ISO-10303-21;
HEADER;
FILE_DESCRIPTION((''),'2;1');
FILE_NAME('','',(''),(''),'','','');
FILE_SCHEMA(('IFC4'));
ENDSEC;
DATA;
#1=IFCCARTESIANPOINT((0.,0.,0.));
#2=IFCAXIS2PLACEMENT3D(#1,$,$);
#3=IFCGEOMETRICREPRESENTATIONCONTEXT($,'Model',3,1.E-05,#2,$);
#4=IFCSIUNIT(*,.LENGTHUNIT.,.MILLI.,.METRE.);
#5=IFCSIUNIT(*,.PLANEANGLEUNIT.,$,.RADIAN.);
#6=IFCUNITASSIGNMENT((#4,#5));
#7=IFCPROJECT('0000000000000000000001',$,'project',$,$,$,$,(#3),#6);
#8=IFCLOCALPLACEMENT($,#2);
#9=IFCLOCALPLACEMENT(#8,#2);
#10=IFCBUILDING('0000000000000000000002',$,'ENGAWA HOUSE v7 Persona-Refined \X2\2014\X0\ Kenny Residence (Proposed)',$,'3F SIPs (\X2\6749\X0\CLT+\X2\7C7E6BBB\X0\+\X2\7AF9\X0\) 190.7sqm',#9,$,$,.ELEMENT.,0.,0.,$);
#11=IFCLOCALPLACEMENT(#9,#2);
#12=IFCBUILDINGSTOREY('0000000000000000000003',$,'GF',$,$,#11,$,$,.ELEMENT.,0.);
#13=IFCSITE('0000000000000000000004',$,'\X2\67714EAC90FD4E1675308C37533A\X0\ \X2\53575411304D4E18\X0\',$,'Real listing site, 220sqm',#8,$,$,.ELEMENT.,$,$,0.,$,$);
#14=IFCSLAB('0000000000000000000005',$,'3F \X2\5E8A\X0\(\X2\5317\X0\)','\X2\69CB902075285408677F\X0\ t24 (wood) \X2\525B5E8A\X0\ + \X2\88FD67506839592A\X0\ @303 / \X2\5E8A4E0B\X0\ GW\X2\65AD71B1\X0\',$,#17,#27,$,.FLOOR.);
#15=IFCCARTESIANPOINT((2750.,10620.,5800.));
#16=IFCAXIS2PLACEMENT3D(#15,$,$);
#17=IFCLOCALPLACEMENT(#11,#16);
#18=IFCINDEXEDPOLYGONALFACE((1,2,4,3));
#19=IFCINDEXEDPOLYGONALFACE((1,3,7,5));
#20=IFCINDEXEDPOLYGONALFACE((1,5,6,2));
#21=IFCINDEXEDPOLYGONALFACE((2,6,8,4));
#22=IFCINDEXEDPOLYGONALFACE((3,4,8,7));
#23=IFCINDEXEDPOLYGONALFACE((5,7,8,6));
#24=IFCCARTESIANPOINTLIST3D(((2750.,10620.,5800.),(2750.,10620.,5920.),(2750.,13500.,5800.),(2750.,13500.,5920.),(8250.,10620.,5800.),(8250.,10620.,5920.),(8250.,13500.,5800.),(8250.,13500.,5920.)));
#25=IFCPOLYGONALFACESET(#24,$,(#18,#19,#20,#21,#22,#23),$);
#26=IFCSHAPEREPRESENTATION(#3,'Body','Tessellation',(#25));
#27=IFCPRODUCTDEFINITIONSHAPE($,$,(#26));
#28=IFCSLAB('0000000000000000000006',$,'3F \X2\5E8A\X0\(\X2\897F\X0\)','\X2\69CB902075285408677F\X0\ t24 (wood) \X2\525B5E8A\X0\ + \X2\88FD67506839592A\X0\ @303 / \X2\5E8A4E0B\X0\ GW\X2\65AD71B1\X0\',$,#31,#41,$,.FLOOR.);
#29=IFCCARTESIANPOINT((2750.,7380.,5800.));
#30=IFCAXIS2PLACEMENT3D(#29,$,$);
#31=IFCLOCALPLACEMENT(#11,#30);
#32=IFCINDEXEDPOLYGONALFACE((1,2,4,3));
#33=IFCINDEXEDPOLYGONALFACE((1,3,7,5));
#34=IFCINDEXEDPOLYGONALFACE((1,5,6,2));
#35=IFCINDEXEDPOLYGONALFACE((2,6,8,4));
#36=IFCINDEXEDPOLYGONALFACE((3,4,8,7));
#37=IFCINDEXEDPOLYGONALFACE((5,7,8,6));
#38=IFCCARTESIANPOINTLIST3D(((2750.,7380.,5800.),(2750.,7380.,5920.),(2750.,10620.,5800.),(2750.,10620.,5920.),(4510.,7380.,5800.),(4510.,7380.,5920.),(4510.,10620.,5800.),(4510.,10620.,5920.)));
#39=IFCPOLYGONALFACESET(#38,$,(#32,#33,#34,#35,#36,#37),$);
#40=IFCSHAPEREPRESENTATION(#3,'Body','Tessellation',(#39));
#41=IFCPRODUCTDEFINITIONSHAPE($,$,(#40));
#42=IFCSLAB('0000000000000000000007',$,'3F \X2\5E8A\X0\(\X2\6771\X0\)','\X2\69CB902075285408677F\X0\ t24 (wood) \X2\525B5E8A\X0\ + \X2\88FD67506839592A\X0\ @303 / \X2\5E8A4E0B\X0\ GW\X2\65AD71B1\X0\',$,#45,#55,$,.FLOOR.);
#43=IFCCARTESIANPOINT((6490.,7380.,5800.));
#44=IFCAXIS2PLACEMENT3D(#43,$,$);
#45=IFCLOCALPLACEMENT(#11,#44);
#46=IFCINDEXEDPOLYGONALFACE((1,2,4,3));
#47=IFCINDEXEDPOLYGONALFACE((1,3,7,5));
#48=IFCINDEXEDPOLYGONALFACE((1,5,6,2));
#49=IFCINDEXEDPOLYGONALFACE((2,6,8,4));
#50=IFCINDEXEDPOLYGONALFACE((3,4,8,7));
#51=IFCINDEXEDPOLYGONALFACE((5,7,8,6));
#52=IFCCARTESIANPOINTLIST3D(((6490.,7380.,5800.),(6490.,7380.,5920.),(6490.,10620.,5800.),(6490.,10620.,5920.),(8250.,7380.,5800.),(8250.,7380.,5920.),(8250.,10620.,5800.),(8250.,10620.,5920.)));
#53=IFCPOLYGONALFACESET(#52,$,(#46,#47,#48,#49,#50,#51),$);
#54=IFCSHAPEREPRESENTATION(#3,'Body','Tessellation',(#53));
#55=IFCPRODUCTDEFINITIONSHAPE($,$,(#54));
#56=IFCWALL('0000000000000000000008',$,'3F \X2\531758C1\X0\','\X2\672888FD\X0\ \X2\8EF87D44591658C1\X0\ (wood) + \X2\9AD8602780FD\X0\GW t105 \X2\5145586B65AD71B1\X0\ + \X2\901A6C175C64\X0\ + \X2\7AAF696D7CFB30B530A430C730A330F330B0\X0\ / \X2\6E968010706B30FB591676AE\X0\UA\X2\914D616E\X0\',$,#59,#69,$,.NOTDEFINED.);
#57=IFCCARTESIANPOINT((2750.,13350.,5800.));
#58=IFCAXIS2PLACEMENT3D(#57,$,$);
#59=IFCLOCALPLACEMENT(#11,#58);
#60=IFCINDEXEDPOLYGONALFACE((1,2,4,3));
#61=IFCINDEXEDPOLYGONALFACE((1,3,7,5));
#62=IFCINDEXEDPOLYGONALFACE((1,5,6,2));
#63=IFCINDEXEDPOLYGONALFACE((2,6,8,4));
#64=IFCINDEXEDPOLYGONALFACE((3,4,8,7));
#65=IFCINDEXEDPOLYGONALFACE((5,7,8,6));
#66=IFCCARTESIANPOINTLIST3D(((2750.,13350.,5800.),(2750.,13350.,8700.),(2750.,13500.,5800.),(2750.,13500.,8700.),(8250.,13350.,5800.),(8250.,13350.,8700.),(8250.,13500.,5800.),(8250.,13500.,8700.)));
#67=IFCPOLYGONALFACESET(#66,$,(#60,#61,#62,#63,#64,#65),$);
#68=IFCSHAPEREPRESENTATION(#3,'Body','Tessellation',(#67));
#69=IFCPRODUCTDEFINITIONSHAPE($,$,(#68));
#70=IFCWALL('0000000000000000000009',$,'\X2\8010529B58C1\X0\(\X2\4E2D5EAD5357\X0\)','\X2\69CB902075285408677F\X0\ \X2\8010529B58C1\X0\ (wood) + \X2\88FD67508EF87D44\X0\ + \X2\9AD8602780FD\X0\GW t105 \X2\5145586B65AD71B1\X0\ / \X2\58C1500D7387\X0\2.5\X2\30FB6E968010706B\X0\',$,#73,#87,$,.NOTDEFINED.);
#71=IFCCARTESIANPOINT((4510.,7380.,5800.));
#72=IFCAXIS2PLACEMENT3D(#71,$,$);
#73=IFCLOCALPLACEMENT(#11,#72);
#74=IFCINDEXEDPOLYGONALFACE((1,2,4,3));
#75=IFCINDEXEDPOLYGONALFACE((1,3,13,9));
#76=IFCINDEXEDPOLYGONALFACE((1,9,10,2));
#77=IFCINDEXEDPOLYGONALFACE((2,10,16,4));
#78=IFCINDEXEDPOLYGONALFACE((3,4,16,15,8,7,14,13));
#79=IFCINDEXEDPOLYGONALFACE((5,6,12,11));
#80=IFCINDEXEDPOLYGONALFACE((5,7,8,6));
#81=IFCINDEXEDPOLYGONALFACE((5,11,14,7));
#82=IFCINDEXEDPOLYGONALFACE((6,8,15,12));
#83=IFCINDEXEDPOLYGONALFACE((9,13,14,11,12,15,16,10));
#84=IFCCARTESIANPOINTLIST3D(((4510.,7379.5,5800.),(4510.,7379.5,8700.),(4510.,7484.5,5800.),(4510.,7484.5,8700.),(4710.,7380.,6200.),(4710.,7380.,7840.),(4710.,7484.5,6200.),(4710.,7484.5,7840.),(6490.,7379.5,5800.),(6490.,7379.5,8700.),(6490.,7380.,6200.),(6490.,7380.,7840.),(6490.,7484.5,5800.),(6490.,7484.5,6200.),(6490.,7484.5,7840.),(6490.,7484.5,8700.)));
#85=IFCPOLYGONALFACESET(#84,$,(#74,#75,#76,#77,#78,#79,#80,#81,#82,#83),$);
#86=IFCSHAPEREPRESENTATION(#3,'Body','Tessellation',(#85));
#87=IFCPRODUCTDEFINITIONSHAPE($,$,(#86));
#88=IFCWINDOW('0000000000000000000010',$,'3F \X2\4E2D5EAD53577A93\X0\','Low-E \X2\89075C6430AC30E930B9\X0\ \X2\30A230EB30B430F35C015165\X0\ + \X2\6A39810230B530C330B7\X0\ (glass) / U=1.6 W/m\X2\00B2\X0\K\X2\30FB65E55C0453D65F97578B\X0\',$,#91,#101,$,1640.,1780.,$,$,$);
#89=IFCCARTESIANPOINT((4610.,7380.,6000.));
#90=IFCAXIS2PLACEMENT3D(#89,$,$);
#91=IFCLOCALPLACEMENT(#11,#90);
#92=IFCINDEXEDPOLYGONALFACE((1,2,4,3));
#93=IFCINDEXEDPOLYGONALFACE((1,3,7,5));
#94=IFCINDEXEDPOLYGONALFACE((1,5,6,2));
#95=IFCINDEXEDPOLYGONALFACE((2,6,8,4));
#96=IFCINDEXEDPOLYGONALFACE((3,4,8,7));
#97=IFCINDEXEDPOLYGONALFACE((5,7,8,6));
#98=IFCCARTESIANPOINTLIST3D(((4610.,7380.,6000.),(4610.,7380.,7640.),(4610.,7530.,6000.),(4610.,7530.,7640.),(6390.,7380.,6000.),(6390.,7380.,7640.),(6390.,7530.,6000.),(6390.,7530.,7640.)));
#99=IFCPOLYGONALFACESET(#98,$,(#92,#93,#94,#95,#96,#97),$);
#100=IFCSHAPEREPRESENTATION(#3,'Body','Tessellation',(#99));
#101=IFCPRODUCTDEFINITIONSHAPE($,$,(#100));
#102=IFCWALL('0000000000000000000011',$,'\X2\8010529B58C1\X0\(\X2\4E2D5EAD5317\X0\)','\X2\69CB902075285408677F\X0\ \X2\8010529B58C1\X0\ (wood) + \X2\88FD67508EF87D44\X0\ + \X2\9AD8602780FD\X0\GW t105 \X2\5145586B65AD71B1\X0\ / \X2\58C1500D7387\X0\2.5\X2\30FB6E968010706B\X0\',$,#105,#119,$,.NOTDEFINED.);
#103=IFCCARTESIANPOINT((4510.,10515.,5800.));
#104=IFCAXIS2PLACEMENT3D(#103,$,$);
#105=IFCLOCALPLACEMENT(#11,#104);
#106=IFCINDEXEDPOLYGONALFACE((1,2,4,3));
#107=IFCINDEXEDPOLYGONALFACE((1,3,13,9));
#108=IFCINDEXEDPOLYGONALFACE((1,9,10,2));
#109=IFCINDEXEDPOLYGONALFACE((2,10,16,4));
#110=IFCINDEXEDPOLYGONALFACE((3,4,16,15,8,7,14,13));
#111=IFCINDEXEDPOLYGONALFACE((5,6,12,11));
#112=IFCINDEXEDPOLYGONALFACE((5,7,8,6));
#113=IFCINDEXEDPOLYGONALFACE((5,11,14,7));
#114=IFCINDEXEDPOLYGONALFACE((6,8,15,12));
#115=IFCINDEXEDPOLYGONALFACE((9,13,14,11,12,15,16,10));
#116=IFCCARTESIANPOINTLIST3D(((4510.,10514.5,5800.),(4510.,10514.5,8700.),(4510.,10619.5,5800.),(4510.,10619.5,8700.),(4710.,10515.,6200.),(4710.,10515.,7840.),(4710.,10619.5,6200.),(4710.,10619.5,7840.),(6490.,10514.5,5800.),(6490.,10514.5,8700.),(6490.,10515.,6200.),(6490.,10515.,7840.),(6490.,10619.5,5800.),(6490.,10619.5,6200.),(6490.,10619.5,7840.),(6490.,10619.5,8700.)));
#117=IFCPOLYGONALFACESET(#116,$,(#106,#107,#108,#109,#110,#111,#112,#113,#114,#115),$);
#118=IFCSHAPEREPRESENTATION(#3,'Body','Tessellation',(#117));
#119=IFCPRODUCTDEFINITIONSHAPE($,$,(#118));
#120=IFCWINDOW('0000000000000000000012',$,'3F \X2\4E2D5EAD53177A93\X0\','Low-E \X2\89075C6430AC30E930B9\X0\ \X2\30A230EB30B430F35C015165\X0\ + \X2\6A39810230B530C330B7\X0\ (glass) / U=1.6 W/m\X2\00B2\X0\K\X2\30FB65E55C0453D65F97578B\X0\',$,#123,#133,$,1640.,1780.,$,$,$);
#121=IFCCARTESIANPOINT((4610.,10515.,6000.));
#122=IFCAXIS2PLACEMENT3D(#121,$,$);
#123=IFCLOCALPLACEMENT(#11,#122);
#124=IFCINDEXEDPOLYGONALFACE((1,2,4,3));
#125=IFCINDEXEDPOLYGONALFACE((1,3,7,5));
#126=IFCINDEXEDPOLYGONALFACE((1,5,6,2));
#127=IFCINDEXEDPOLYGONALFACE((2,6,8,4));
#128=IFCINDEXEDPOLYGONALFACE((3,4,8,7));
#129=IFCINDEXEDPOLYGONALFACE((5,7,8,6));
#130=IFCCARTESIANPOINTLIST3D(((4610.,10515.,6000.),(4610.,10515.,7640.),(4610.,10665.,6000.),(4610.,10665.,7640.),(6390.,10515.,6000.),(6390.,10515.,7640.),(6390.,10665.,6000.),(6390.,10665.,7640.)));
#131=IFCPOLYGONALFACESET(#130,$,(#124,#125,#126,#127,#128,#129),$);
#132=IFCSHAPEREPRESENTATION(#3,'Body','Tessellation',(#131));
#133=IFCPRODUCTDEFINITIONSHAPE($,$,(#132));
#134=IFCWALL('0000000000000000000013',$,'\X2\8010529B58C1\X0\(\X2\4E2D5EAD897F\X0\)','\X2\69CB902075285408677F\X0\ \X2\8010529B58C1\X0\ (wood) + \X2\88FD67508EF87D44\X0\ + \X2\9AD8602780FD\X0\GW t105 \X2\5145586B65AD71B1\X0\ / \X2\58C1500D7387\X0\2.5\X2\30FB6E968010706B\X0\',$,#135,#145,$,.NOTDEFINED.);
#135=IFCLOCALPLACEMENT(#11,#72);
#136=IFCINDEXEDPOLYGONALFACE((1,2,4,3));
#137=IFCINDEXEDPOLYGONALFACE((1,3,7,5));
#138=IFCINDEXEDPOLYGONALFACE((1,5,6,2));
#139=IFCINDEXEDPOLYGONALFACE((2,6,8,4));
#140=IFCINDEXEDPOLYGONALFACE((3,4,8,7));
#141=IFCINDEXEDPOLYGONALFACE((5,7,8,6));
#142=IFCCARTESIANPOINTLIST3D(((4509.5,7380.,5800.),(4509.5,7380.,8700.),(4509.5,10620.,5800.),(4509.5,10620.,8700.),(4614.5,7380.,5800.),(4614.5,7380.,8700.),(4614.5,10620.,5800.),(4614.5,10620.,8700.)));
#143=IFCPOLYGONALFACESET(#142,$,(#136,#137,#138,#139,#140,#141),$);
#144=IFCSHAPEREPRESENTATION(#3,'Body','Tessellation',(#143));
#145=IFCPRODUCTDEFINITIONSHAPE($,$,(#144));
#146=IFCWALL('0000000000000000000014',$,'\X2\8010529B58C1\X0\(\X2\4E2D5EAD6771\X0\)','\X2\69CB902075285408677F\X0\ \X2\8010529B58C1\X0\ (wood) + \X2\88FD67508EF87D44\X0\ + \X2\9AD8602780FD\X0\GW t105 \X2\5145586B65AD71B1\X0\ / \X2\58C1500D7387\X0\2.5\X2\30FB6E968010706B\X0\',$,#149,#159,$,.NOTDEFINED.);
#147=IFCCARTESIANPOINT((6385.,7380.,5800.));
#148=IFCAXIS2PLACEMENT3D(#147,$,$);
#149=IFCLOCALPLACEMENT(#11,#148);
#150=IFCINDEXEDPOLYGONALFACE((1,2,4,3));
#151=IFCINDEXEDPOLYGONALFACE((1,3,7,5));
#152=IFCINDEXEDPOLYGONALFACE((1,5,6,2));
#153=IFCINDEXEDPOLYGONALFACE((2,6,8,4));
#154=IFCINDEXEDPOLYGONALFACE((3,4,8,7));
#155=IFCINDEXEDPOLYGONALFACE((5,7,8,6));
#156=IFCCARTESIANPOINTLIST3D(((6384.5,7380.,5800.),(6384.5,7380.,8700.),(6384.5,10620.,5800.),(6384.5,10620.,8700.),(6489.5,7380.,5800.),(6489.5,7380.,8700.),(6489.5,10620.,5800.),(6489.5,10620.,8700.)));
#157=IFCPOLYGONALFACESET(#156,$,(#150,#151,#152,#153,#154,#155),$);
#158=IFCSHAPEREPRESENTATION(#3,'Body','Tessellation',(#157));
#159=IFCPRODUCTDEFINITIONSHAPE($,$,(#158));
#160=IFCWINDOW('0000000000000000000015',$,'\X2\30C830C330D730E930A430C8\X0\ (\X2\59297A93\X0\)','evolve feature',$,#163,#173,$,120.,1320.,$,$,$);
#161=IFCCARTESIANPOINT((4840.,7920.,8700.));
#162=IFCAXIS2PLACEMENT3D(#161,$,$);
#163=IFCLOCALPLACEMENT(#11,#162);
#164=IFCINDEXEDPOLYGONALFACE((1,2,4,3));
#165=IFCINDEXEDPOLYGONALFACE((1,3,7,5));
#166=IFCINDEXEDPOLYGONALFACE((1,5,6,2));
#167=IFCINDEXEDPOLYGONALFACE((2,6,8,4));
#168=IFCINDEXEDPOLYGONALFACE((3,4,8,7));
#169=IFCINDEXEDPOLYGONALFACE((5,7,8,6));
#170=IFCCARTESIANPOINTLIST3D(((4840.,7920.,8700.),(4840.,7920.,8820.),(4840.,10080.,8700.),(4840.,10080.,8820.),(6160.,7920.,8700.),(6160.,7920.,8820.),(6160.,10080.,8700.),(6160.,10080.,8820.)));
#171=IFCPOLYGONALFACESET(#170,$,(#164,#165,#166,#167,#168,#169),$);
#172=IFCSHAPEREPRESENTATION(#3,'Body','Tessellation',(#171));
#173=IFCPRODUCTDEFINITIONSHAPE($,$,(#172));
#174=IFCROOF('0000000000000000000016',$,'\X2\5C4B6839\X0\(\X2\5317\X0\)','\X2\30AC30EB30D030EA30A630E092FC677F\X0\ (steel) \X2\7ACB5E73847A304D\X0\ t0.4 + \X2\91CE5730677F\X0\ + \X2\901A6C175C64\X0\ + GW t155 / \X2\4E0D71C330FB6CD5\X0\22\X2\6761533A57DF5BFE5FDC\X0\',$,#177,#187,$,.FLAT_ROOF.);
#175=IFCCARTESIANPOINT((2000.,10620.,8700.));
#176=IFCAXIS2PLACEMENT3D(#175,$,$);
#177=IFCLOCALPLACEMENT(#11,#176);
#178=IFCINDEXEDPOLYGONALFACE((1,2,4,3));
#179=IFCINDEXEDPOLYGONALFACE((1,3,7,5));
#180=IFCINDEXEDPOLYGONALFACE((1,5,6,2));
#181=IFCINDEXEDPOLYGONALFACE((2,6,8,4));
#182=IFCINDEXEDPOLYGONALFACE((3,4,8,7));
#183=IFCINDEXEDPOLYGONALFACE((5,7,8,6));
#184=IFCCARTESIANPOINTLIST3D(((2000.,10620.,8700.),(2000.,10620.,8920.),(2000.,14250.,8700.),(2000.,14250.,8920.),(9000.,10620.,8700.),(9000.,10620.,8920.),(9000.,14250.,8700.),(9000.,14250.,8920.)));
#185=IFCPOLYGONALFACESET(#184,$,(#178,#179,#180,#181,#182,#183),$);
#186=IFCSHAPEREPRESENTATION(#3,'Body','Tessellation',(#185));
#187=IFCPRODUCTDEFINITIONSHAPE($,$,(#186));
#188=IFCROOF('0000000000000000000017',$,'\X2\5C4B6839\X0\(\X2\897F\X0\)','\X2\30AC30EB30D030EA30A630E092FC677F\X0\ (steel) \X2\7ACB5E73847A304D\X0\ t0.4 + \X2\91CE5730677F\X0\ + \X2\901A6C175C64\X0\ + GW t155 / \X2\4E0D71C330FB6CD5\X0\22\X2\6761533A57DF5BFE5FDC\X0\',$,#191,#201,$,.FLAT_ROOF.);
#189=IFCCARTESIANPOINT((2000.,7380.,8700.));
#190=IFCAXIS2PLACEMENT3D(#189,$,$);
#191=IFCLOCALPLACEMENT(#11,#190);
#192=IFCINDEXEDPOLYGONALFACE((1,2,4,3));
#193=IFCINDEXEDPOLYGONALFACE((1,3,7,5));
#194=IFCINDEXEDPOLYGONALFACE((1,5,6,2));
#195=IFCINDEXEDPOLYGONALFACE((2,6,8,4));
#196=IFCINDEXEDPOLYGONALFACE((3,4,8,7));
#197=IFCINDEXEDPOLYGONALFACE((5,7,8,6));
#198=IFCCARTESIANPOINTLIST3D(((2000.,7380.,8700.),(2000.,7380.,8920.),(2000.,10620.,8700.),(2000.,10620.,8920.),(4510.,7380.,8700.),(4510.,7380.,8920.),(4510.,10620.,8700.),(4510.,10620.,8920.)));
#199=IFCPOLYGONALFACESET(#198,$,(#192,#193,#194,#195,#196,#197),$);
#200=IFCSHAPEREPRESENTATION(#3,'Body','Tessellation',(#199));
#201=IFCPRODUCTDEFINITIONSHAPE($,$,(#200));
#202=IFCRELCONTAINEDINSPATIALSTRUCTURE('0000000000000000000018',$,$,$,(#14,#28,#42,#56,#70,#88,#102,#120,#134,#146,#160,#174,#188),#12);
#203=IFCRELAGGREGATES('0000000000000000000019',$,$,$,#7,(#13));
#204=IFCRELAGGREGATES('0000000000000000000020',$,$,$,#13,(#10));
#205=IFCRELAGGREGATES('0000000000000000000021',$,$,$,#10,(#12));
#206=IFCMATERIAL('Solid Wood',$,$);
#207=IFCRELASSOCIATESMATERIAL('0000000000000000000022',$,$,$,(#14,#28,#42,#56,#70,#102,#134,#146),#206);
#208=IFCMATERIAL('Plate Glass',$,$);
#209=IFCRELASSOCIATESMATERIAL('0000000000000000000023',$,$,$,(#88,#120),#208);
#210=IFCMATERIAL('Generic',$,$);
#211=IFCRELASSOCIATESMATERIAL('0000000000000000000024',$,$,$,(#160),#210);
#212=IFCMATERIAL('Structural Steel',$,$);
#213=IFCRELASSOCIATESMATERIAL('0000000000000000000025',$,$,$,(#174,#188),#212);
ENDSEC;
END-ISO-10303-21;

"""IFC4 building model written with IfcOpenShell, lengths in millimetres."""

from ifc_helpers import new_model, si_unit, frame, frame_2d, origin, place, context, project, spatial, rectangle, extrude, material, element, fill, save


model = new_model("IFC4")

# Units and contexts
model_context = context("Model", 3, precision=1e-05, world=origin())
ifc_project = project(units=[si_unit("LENGTHUNIT", "METRE", prefix="MILLI"), si_unit("PLANEANGLEUNIT", "RADIAN")], contexts=[model_context])

# Site, building, storey
site_placement = place(None, origin())
site = spatial("IfcSite", under=ifc_project, at=site_placement, Name="東京都世田谷区 南向き丘", ObjectType="Real listing site, 220sqm", CompositionType="ELEMENT", RefElevation=0.0)
building_placement = place(site_placement, origin())
building = spatial("IfcBuilding", under=site, at=building_placement, Name="ENGAWA HOUSE v7 Persona-Refined — Kenny Residence (Proposed)", ObjectType="3F SIPs (杉CLT+籾殻+竹) 190.7sqm", CompositionType="ELEMENT", ElevationOfRefHeight=0.0, ElevationOfTerrain=0.0)
storey_placement = place(building_placement, origin())
storey = spatial("IfcBuildingStorey", under=building, at=storey_placement, Name="GF", CompositionType="ELEMENT", Elevation=0.0)

# Slabs
ifc_material_1 = material(Name="Solid Wood")
slab_1_placement = place(storey_placement, frame((2750.0, 10620.0, 5800.0)))
element("IfcSlab", 1, at=slab_1_placement, inside=storey, material=ifc_material_1, Name="3F 床(北)", Description="構造用合板 t24 (wood) 剛床 + 製材根太 @303 / 床下 GW断熱", PredefinedType="FLOOR", context=model_context, shape_type="SweptSolid", body=[
    extrude(rectangle(XDim=5500.0, YDim=2880.0, at=frame_2d((2750.0, 1440.0))), frame((2750.0, 10620.0, 5800.0)), (0.0, 0.0, 1.0), 120.0),
])
slab_2_placement = place(storey_placement, frame((2750.0, 7380.0, 5800.0)))
element("IfcSlab", 2, at=slab_2_placement, inside=storey, material=ifc_material_1, Name="3F 床(西)", Description="構造用合板 t24 (wood) 剛床 + 製材根太 @303 / 床下 GW断熱", PredefinedType="FLOOR", context=model_context, shape_type="SweptSolid", body=[
    extrude(rectangle(XDim=1760.0, YDim=3240.0, at=frame_2d((880.0, 1620.0))), frame((2750.0, 7380.0, 5800.0)), (0.0, 0.0, 1.0), 120.0),
])
slab_3_placement = place(storey_placement, frame((6490.0, 7380.0, 5800.0)))
element("IfcSlab", 3, at=slab_3_placement, inside=storey, material=ifc_material_1, Name="3F 床(東)", Description="構造用合板 t24 (wood) 剛床 + 製材根太 @303 / 床下 GW断熱", PredefinedType="FLOOR", context=model_context, shape_type="SweptSolid", body=[
    extrude(rectangle(XDim=1760.0, YDim=3240.0, at=frame_2d((880.0, 1620.0))), frame((6490.0, 7380.0, 5800.0)), (0.0, 0.0, 1.0), 120.0),
])

# Wall
wall_1_placement = place(storey_placement, frame((2750.0, 13350.0, 5800.0)))
element("IfcWall", 4, at=wall_1_placement, inside=storey, material=ifc_material_1, Name="3F 北壁", Description="木製 軸組外壁 (wood) + 高性能GW t105 充填断熱 + 通気層 + 窯業系サイディング / 準耐火・外皮UA配慮", PredefinedType="NOTDEFINED", context=model_context, shape_type="SweptSolid", body=[
    extrude(rectangle(XDim=5500.0, YDim=150.0, at=frame_2d((2750.0, 75.0))), frame((2750.0, 13350.0, 5800.0)), (0.0, 0.0, 1.0), 2900.0),
])

# Walls, openings, windows
wall_2_placement = place(storey_placement, frame((4510.0, 7380.0, 5800.0)))
wall_2 = element("IfcWall", 5, at=wall_2_placement, inside=storey, material=ifc_material_1, Name="耐力壁(中庭南)", Description="構造用合板 耐力壁 (wood) + 製材軸組 + 高性能GW t105 充填断熱 / 壁倍率2.5・準耐火", PredefinedType="NOTDEFINED", context=model_context, shape_type="SweptSolid", body=[
    extrude(rectangle(XDim=1980.0, YDim=105.0, at=frame_2d((990.0, 52.0))), frame((4510.0, 7380.0, 5800.0)), (0.0, 0.0, 1.0), 2900.0),
])
opening_1_placement = place(storey_placement, frame((4610.0, 7380.0, 6000.0)))
opening_1 = element("IfcOpeningElement", 6, at=opening_1_placement, cuts=wall_2, PredefinedType="NOTDEFINED", context=model_context, shape_type="SweptSolid", body=[
    extrude(rectangle(XDim=1780.0, YDim=150.0, at=frame_2d((890.0, 75.0))), frame((4610.0, 7380.0, 6000.0)), (0.0, 0.0, 1.0), 1640.0),
])
ifc_material_2 = material(Name="Plate Glass")
window_1_placement = place(storey_placement, frame((4610.0, 7380.0, 6000.0)))
window_1 = element("IfcWindow", 7, at=window_1_placement, inside=storey, material=ifc_material_2, Name="3F 中庭南窓", Description="Low-E 複層ガラス アルゴン封入 + 樹脂サッシ (glass) / U=1.6 W/m²K・日射取得型", OverallHeight=1640.0, OverallWidth=1780.0, context=model_context, shape_type="SweptSolid", body=[
    extrude(rectangle(XDim=1780.0, YDim=150.0, at=frame_2d((890.0, 75.0))), frame((4610.0, 7380.0, 6000.0)), (0.0, 0.0, 1.0), 1640.0),
])
fill(opening_1, window_1)
wall_3_placement = place(storey_placement, frame((4510.0, 10515.0, 5800.0)))
wall_3 = element("IfcWall", 8, at=wall_3_placement, inside=storey, material=ifc_material_1, Name="耐力壁(中庭北)", Description="構造用合板 耐力壁 (wood) + 製材軸組 + 高性能GW t105 充填断熱 / 壁倍率2.5・準耐火", PredefinedType="NOTDEFINED", context=model_context, shape_type="SweptSolid", body=[
    extrude(rectangle(XDim=1980.0, YDim=105.0, at=frame_2d((990.0, 52.0))), frame((4510.0, 10515.0, 5800.0)), (0.0, 0.0, 1.0), 2900.0),
])
opening_2_placement = place(storey_placement, frame((4610.0, 10515.0, 6000.0)))
opening_2 = element("IfcOpeningElement", 9, at=opening_2_placement, cuts=wall_3, PredefinedType="NOTDEFINED", context=model_context, shape_type="SweptSolid", body=[
    extrude(rectangle(XDim=1780.0, YDim=150.0, at=frame_2d((890.0, 75.0))), frame((4610.0, 10515.0, 6000.0)), (0.0, 0.0, 1.0), 1640.0),
])
window_2_placement = place(storey_placement, frame((4610.0, 10515.0, 6000.0)))
window_2 = element("IfcWindow", 10, at=window_2_placement, inside=storey, material=ifc_material_2, Name="3F 中庭北窓", Description="Low-E 複層ガラス アルゴン封入 + 樹脂サッシ (glass) / U=1.6 W/m²K・日射取得型", OverallHeight=1640.0, OverallWidth=1780.0, context=model_context, shape_type="SweptSolid", body=[
    extrude(rectangle(XDim=1780.0, YDim=150.0, at=frame_2d((890.0, 75.0))), frame((4610.0, 10515.0, 6000.0)), (0.0, 0.0, 1.0), 1640.0),
])
fill(opening_2, window_2)

# Walls
wall_4_placement = place(storey_placement, frame((4510.0, 7380.0, 5800.0)))
element("IfcWall", 11, at=wall_4_placement, inside=storey, material=ifc_material_1, Name="耐力壁(中庭西)", Description="構造用合板 耐力壁 (wood) + 製材軸組 + 高性能GW t105 充填断熱 / 壁倍率2.5・準耐火", PredefinedType="NOTDEFINED", context=model_context, shape_type="SweptSolid", body=[
    extrude(rectangle(XDim=105.0, YDim=3240.0, at=frame_2d((52.0, 1620.0))), frame((4510.0, 7380.0, 5800.0)), (0.0, 0.0, 1.0), 2900.0),
])
wall_5_placement = place(storey_placement, frame((6385.0, 7380.0, 5800.0)))
element("IfcWall", 12, at=wall_5_placement, inside=storey, material=ifc_material_1, Name="耐力壁(中庭東)", Description="構造用合板 耐力壁 (wood) + 製材軸組 + 高性能GW t105 充填断熱 / 壁倍率2.5・準耐火", PredefinedType="NOTDEFINED", context=model_context, shape_type="SweptSolid", body=[
    extrude(rectangle(XDim=105.0, YDim=3240.0, at=frame_2d((52.0, 1620.0))), frame((6385.0, 7380.0, 5800.0)), (0.0, 0.0, 1.0), 2900.0),
])

# Window
ifc_material_3 = material(Name="Generic")
window_3_placement = place(storey_placement, frame((4840.0, 7920.0, 8700.0)))
element("IfcWindow", 13, at=window_3_placement, inside=storey, material=ifc_material_3, Name="トップライト (天窓)", Description="evolve feature", OverallHeight=120.0, OverallWidth=1320.0, context=model_context, shape_type="SweptSolid", body=[
    extrude(rectangle(XDim=1320.0, YDim=2160.0, at=frame_2d((660.0, 1080.0))), frame((4840.0, 7920.0, 8700.0)), (0.0, 0.0, 1.0), 120.0),
])

# Roofs
ifc_material_4 = material(Name="Structural Steel")
for number, where, name in (
    (14, (2000.0, 10620.0, 8700.0), "屋根(北)"),
):
    element("IfcRoof", number, at=place(storey_placement, frame(where)), inside=storey, material=ifc_material_4, Name=name, Description="ガルバリウム鋼板 (steel) 立平葺き t0.4 + 野地板 + 通気層 + GW t155 / 不燃・法22条区域対応", PredefinedType="FLAT_ROOF", context=model_context, shape_type="SweptSolid", body=[
        extrude(rectangle(XDim=7000.0, YDim=3630.0, at=frame_2d((3500.0, 1815.0))), frame((2000.0, 10620.0, 8700.0)), (0.0, 0.0, 1.0), 220.0),
    ])
roof_1_placement = place(storey_placement, frame((2000.0, 7380.0, 8700.0)))
element("IfcRoof", 15, at=roof_1_placement, inside=storey, material=ifc_material_4, Name="屋根(西)", Description="ガルバリウム鋼板 (steel) 立平葺き t0.4 + 野地板 + 通気層 + GW t155 / 不燃・法22条区域対応", PredefinedType="FLAT_ROOF", context=model_context, shape_type="SweptSolid", body=[
    extrude(rectangle(XDim=2510.0, YDim=3240.0, at=frame_2d((1255.0, 1620.0))), frame((2000.0, 7380.0, 8700.0)), (0.0, 0.0, 1.0), 220.0),
])

save(model, "model.ifc")
